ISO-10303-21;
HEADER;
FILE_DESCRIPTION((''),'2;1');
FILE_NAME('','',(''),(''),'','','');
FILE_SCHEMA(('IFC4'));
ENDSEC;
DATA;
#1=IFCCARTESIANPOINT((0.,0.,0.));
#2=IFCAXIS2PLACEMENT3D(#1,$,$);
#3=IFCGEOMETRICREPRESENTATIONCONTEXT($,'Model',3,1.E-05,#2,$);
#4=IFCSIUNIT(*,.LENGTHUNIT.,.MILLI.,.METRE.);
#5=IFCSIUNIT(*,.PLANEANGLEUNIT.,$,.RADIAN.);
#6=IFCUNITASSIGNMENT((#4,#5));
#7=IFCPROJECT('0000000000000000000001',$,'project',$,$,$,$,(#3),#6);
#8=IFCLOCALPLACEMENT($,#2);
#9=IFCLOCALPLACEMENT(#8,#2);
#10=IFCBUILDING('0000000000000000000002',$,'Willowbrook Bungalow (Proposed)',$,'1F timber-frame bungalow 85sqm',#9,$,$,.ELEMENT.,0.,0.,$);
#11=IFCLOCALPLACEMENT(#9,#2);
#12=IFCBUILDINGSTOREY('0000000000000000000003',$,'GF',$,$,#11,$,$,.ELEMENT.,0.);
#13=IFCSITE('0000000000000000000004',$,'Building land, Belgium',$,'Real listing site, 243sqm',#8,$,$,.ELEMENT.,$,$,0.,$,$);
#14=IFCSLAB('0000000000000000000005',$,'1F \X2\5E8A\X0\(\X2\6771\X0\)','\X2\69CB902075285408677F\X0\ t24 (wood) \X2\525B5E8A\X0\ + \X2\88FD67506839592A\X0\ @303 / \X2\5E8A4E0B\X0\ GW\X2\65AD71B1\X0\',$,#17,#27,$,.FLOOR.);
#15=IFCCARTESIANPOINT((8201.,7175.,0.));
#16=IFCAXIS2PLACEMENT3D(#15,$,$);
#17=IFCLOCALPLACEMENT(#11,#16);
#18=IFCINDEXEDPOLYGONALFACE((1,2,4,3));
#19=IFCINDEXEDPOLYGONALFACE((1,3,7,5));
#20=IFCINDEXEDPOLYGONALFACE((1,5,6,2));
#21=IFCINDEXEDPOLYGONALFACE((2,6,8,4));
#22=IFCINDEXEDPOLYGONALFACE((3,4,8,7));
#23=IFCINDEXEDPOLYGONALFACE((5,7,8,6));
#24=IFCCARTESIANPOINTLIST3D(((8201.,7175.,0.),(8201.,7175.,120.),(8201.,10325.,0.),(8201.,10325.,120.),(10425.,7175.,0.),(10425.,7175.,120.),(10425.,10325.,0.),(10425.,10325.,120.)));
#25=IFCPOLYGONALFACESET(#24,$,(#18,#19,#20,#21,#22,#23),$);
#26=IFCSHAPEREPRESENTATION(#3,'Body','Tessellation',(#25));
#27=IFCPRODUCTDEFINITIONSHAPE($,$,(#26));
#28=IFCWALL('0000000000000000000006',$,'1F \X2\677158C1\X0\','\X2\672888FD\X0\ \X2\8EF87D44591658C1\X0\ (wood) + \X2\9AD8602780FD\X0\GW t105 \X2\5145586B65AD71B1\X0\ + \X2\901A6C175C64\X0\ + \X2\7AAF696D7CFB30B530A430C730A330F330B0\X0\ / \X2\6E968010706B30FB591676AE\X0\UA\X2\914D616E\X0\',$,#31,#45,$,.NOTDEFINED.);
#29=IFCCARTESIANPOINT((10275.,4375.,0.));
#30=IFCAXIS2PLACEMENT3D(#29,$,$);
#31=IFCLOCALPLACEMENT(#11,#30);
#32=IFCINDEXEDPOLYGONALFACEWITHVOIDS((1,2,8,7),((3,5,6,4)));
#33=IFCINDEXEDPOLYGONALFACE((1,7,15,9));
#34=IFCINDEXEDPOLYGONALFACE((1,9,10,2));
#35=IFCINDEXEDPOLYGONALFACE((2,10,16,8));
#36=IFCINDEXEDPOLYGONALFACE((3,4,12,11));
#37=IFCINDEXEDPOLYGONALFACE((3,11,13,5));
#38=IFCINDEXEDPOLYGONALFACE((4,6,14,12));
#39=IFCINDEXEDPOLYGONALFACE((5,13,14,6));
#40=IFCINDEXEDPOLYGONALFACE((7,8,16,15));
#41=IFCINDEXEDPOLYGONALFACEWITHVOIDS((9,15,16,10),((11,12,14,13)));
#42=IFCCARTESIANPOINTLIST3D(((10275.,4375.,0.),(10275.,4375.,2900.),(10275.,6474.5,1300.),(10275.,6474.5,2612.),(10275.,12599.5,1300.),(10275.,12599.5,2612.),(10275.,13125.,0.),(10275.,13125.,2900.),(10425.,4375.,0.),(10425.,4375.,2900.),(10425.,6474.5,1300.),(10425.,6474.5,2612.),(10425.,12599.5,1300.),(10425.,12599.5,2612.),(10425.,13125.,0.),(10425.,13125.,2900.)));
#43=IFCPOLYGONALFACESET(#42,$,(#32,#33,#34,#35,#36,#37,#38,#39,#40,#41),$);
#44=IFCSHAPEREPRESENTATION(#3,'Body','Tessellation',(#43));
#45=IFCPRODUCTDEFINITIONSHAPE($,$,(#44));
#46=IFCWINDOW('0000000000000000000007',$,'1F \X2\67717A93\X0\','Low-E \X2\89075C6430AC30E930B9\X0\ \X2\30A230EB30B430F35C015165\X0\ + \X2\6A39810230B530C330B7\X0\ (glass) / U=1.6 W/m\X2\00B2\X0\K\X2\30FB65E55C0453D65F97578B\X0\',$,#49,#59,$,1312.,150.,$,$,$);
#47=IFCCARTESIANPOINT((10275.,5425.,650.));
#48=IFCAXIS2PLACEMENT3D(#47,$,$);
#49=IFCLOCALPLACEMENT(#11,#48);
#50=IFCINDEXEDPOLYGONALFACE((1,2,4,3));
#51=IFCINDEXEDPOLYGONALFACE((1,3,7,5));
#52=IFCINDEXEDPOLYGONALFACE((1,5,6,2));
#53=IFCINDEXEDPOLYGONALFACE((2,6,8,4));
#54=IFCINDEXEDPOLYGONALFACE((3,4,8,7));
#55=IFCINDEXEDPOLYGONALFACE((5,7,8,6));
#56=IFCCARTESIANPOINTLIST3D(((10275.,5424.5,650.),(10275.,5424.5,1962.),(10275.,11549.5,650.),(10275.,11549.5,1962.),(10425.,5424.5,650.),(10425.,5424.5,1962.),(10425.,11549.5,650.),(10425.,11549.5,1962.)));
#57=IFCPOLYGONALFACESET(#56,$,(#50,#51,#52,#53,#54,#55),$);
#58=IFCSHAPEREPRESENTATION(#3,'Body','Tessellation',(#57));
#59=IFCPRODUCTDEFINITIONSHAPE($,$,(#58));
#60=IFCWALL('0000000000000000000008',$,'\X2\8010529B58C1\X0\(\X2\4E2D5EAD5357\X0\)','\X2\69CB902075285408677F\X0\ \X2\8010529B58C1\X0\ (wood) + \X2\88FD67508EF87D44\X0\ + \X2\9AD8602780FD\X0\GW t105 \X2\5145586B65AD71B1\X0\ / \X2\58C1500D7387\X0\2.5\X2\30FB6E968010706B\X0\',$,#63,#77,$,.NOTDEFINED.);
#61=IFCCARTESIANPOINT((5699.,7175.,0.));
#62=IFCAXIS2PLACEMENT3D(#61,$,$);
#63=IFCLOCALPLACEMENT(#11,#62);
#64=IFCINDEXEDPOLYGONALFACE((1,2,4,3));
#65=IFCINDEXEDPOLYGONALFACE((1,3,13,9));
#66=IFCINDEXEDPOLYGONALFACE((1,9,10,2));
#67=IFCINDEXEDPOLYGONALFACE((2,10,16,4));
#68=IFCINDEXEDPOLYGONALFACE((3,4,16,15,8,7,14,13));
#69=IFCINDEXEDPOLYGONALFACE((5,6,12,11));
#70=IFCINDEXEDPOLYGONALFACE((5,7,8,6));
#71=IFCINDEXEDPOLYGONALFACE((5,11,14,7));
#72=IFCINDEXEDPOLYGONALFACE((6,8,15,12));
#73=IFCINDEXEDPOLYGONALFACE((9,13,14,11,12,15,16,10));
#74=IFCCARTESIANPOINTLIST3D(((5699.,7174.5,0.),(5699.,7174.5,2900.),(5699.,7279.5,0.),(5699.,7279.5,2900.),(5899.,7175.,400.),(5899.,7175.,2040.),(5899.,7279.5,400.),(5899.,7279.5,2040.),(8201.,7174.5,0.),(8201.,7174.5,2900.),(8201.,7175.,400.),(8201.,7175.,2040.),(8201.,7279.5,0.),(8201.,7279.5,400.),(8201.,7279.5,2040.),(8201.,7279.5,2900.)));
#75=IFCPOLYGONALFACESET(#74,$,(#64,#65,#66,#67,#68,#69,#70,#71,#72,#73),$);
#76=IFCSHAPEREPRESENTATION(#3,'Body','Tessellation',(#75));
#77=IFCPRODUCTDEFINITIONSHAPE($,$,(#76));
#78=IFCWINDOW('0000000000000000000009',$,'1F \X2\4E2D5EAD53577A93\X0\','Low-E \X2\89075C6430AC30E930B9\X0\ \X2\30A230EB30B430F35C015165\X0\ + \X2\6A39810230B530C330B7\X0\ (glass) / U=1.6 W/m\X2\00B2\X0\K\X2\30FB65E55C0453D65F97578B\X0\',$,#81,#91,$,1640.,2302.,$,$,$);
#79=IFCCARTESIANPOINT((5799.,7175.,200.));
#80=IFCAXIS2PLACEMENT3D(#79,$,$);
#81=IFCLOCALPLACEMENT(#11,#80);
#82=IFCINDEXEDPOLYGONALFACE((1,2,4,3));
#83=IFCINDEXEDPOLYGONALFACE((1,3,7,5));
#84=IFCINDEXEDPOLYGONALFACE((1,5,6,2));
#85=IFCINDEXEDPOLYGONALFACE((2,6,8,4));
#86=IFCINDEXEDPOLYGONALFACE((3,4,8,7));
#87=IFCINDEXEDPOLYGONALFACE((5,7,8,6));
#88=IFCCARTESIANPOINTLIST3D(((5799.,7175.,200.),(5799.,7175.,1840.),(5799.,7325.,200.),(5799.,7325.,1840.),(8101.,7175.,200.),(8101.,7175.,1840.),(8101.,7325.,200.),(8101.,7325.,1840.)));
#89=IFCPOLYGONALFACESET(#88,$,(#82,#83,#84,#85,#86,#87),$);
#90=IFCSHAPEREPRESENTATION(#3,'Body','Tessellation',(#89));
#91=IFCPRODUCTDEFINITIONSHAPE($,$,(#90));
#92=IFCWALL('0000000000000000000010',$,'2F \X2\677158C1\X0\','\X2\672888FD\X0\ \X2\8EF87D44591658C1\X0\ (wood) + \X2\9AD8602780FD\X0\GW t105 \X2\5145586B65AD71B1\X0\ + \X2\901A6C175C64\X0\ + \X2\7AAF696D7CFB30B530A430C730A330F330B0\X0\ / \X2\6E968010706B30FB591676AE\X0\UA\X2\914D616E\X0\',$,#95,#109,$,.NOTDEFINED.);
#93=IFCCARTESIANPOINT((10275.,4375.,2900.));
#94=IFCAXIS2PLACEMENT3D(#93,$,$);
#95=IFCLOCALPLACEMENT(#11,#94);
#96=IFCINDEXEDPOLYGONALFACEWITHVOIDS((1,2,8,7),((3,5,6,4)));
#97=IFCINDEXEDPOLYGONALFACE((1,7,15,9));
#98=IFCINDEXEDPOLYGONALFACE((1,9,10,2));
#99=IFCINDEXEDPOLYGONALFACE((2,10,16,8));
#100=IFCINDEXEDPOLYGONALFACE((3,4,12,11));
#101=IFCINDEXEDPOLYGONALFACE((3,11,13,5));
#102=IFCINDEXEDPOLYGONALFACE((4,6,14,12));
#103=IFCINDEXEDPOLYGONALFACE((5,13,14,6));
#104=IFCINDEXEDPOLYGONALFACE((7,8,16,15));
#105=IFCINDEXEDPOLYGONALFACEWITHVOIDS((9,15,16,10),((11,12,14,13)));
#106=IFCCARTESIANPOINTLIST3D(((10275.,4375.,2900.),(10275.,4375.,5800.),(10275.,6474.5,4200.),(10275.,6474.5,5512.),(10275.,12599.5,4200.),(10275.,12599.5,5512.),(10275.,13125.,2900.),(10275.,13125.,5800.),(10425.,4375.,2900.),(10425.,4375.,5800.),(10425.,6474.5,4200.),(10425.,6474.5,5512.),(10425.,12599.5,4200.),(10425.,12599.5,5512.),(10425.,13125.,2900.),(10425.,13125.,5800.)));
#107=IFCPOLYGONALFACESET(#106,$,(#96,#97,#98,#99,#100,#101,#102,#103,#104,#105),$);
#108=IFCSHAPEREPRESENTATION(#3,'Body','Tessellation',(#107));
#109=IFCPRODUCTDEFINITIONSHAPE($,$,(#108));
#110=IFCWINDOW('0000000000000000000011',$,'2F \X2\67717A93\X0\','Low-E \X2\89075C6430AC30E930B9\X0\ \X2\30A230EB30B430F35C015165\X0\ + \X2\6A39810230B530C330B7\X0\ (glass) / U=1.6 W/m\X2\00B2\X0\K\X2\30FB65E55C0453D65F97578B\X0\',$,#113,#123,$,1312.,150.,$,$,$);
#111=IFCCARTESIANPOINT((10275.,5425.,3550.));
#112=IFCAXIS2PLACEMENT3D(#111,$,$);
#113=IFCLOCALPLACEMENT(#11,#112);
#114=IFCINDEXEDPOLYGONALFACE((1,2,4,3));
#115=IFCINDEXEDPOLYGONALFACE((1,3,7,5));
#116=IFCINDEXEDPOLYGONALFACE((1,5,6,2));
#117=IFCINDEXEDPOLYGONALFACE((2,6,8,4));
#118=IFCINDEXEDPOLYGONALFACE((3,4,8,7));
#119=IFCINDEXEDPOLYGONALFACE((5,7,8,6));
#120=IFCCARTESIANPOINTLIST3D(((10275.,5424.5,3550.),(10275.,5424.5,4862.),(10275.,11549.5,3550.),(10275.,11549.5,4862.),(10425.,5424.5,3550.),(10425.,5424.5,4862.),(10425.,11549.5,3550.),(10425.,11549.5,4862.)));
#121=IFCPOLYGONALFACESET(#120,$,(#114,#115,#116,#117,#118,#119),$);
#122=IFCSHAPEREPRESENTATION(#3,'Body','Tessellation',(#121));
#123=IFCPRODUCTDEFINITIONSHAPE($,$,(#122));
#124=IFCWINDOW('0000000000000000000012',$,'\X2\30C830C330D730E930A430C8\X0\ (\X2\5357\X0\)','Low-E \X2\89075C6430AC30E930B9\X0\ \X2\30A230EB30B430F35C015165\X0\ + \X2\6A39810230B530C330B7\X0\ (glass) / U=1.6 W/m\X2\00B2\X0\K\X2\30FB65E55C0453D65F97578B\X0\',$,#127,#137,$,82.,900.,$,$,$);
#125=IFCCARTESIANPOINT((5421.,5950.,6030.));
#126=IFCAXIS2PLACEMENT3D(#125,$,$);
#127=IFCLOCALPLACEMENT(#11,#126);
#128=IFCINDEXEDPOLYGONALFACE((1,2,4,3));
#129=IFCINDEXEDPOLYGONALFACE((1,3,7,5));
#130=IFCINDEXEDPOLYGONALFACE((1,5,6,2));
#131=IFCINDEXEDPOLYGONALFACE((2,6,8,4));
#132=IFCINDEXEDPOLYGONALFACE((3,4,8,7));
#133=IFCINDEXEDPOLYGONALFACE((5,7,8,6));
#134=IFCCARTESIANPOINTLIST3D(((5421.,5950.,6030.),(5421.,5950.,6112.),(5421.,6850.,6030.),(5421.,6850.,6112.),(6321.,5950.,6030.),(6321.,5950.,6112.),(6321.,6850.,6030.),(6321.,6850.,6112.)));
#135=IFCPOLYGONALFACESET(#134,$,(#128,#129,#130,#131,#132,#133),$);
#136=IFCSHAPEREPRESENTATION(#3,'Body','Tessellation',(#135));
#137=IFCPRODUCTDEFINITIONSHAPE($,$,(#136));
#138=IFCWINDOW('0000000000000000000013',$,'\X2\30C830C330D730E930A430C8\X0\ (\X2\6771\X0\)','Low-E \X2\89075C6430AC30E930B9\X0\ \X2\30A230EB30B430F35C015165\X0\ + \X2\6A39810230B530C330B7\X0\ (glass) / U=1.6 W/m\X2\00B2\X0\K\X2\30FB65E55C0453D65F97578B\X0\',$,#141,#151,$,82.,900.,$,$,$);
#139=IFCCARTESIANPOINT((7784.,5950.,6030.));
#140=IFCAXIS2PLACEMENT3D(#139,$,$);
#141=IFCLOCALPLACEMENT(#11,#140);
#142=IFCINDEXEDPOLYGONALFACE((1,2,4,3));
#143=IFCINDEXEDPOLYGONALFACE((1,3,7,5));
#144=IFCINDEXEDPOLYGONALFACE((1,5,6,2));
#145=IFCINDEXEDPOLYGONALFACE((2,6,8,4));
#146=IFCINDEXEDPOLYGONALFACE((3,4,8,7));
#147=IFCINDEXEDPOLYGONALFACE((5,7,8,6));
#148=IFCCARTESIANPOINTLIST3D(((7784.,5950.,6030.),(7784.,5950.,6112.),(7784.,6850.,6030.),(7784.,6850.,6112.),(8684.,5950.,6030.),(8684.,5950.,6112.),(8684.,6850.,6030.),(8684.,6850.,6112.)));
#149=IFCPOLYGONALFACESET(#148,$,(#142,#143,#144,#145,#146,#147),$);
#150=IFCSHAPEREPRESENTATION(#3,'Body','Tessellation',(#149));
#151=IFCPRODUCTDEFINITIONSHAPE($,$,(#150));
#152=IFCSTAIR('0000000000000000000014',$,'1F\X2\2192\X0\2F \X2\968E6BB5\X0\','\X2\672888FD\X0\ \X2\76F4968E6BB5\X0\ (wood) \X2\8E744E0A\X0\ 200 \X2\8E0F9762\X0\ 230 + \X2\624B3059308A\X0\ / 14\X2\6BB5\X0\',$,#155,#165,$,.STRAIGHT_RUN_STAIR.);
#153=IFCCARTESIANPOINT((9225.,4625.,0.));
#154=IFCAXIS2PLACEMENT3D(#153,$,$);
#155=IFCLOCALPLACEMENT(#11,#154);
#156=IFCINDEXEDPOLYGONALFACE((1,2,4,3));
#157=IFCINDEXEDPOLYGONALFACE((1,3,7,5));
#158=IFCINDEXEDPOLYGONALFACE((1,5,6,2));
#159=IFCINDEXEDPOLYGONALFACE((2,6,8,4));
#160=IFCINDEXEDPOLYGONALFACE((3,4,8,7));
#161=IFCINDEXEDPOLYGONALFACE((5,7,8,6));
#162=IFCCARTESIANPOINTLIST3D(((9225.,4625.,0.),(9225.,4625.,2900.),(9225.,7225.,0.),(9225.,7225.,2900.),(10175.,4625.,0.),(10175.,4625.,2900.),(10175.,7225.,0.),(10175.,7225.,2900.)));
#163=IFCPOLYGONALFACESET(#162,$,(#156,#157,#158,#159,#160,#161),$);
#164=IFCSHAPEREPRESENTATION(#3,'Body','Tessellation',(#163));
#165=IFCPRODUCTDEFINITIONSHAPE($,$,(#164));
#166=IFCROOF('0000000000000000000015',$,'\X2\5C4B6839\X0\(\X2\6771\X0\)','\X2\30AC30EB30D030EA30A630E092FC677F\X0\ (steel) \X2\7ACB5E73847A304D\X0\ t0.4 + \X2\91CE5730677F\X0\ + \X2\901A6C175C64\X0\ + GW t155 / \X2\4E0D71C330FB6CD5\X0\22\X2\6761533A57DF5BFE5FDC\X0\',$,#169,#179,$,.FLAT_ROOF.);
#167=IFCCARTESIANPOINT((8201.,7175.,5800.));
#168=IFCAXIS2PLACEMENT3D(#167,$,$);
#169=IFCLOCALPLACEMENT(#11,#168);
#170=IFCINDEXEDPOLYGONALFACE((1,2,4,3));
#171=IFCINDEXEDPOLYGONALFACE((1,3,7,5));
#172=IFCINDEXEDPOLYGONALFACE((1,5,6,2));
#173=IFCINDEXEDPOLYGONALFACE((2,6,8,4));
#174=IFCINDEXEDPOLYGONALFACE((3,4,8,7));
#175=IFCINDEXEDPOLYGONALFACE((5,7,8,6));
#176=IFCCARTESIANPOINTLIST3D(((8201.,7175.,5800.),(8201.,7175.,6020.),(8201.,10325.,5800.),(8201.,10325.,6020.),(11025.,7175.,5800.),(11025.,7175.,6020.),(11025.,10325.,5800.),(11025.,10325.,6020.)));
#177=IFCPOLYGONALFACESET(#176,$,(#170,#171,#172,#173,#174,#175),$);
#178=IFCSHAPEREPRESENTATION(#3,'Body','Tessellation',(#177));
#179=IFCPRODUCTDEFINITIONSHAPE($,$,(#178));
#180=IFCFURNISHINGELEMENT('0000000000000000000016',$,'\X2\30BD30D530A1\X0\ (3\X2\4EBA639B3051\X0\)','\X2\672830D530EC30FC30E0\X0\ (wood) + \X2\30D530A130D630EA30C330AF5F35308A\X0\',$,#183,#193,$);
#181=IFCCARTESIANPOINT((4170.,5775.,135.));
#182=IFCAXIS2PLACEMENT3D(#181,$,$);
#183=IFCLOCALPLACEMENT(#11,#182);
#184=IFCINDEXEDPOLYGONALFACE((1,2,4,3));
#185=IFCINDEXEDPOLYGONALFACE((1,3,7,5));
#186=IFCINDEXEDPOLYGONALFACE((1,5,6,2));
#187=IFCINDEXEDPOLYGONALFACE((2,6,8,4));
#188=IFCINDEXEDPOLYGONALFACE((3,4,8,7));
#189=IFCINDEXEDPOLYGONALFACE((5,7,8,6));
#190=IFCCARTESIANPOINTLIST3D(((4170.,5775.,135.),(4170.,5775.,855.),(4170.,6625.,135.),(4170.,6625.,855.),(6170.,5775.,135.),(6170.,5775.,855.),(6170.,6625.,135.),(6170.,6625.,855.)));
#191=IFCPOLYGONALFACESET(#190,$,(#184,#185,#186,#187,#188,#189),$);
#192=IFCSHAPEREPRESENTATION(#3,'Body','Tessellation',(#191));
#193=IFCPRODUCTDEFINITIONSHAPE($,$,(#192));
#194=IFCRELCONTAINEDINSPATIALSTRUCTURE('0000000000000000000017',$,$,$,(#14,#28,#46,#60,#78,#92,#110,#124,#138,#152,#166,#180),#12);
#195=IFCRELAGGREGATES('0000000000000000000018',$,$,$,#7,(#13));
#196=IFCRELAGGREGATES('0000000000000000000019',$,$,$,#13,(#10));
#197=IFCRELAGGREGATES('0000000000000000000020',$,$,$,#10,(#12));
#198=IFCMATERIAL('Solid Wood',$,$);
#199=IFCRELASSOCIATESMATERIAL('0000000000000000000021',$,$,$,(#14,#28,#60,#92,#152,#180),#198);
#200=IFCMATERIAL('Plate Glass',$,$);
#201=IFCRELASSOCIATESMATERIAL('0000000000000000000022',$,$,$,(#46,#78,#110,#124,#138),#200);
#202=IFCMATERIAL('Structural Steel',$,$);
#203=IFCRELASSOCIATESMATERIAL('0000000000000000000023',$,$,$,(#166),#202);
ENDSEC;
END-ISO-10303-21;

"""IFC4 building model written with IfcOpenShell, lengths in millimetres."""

from ifc_helpers import new_model, si_unit, frame, frame_2d, origin, place, context, project, spatial, rectangle, extrude, material, element, fill, save


model = new_model("IFC4")

# Units and contexts
model_context = context("Model", 3, precision=1e-05, world=origin())
ifc_project = project(units=[si_unit("LENGTHUNIT", "METRE", prefix="MILLI"), si_unit("PLANEANGLEUNIT", "RADIAN")], contexts=[model_context])

# Site, building, storey
site_placement = place(None, origin())
site = spatial("IfcSite", under=ifc_project, at=site_placement, Name="Building land, Belgium", ObjectType="Real listing site, 243sqm", CompositionType="ELEMENT", RefElevation=0.0)
building_placement = place(site_placement, origin())
building = spatial("IfcBuilding", under=site, at=building_placement, Name="Willowbrook Bungalow (Proposed)", ObjectType="1F timber-frame bungalow 85sqm", CompositionType="ELEMENT", ElevationOfRefHeight=0.0, ElevationOfTerrain=0.0)
storey_placement = place(building_placement, origin())
storey = spatial("IfcBuildingStorey", under=building, at=storey_placement, Name="GF", CompositionType="ELEMENT", Elevation=0.0)

# Slab
ifc_material_1 = material(Name="Solid Wood")
slab_placement = place(storey_placement, frame((8201.0, 7175.0, 0.0)))
element("IfcSlab", 1, at=slab_placement, inside=storey, material=ifc_material_1, Name="1F 床(東)", Description="構造用合板 t24 (wood) 剛床 + 製材根太 @303 / 床下 GW断熱", PredefinedType="FLOOR", context=model_context, shape_type="SweptSolid", body=[
    extrude(rectangle(XDim=2224.0, YDim=3150.0, at=frame_2d((1112.0, 1575.0))), frame((8201.0, 7175.0, 0.0)), (0.0, 0.0, 1.0), 120.0),
])

# Walls, openings, windows
wall_1_placement = place(storey_placement, frame((10275.0, 4375.0, 0.0)))
wall_1 = element("IfcWall", 2, at=wall_1_placement, inside=storey, material=ifc_material_1, Name="1F 東壁", Description="木製 軸組外壁 (wood) + 高性能GW t105 充填断熱 + 通気層 + 窯業系サイディング / 準耐火・外皮UA配慮", PredefinedType="NOTDEFINED", context=model_context, shape_type="SweptSolid", body=[
    extrude(rectangle(XDim=150.0, YDim=8750.0, at=frame_2d((75.0, 4375.0))), frame((10275.0, 4375.0, 0.0)), (0.0, 0.0, 1.0), 2900.0),
])
opening_1_placement = place(storey_placement, frame((10275.0, 5425.0, 650.0)))
opening_1 = element("IfcOpeningElement", 3, at=opening_1_placement, cuts=wall_1, PredefinedType="NOTDEFINED", context=model_context, shape_type="SweptSolid", body=[
    extrude(rectangle(XDim=150.0, YDim=6125.0, at=frame_2d((75.0, 3062.0))), frame((10275.0, 5425.0, 650.0)), (0.0, 0.0, 1.0), 1312.0),
])
ifc_material_2 = material(Name="Plate Glass")
window_1_placement = place(storey_placement, frame((10275.0, 5425.0, 650.0)))
window_1 = element("IfcWindow", 4, at=window_1_placement, inside=storey, material=ifc_material_2, Name="1F 東窓", Description="Low-E 複層ガラス アルゴン封入 + 樹脂サッシ (glass) / U=1.6 W/m²K・日射取得型", OverallHeight=1312.0, OverallWidth=150.0, context=model_context, shape_type="SweptSolid", body=[
    extrude(rectangle(XDim=150.0, YDim=6125.0, at=frame_2d((75.0, 3062.0))), frame((10275.0, 5425.0, 650.0)), (0.0, 0.0, 1.0), 1312.0),
])
fill(opening_1, window_1)
wall_2_placement = place(storey_placement, frame((5699.0, 7175.0, 0.0)))
wall_2 = element("IfcWall", 5, at=wall_2_placement, inside=storey, material=ifc_material_1, Name="耐力壁(中庭南)", Description="構造用合板 耐力壁 (wood) + 製材軸組 + 高性能GW t105 充填断熱 / 壁倍率2.5・準耐火", PredefinedType="NOTDEFINED", context=model_context, shape_type="SweptSolid", body=[
    extrude(rectangle(XDim=2502.0, YDim=105.0, at=frame_2d((1251.0, 52.0))), frame((5699.0, 7175.0, 0.0)), (0.0, 0.0, 1.0), 2900.0),
])
opening_2_placement = place(storey_placement, frame((5799.0, 7175.0, 200.0)))
opening_2 = element("IfcOpeningElement", 6, at=opening_2_placement, cuts=wall_2, PredefinedType="NOTDEFINED", context=model_context, shape_type="SweptSolid", body=[
    extrude(rectangle(XDim=2302.0, YDim=150.0, at=frame_2d((1151.0, 75.0))), frame((5799.0, 7175.0, 200.0)), (0.0, 0.0, 1.0), 1640.0),
])
window_2_placement = place(storey_placement, frame((5799.0, 7175.0, 200.0)))
window_2 = element("IfcWindow", 7, at=window_2_placement, inside=storey, material=ifc_material_2, Name="1F 中庭南窓", Description="Low-E 複層ガラス アルゴン封入 + 樹脂サッシ (glass) / U=1.6 W/m²K・日射取得型", OverallHeight=1640.0, OverallWidth=2302.0, context=model_context, shape_type="SweptSolid", body=[
    extrude(rectangle(XDim=2302.0, YDim=150.0, at=frame_2d((1151.0, 75.0))), frame((5799.0, 7175.0, 200.0)), (0.0, 0.0, 1.0), 1640.0),
])
fill(opening_2, window_2)

# Wall, opening, window
wall_3_placement = place(storey_placement, frame((10275.0, 4375.0, 2900.0)))
wall_3 = element("IfcWall", 8, at=wall_3_placement, inside=storey, material=ifc_material_1, Name="2F 東壁", Description="木製 軸組外壁 (wood) + 高性能GW t105 充填断熱 + 通気層 + 窯業系サイディング / 準耐火・外皮UA配慮", PredefinedType="NOTDEFINED", context=model_context, shape_type="SweptSolid", body=[
    extrude(rectangle(XDim=150.0, YDim=8750.0, at=frame_2d((75.0, 4375.0))), frame((10275.0, 4375.0, 2900.0)), (0.0, 0.0, 1.0), 2900.0),
])
opening_3_placement = place(storey_placement, frame((10275.0, 5425.0, 3550.0)))
opening_3 = element("IfcOpeningElement", 9, at=opening_3_placement, cuts=wall_3, PredefinedType="NOTDEFINED", context=model_context, shape_type="SweptSolid", body=[
    extrude(rectangle(XDim=150.0, YDim=6125.0, at=frame_2d((75.0, 3062.0))), frame((10275.0, 5425.0, 3550.0)), (0.0, 0.0, 1.0), 1312.0),
])
window_3_placement = place(storey_placement, frame((10275.0, 5425.0, 3550.0)))
window_3 = element("IfcWindow", 10, at=window_3_placement, inside=storey, material=ifc_material_2, Name="2F 東窓", Description="Low-E 複層ガラス アルゴン封入 + 樹脂サッシ (glass) / U=1.6 W/m²K・日射取得型", OverallHeight=1312.0, OverallWidth=150.0, context=model_context, shape_type="SweptSolid", body=[
    extrude(rectangle(XDim=150.0, YDim=6125.0, at=frame_2d((75.0, 3062.0))), frame((10275.0, 5425.0, 3550.0)), (0.0, 0.0, 1.0), 1312.0),
])
fill(opening_3, window_3)

# Windows
window_4_placement = place(storey_placement, frame((5421.0, 5950.0, 6030.0)))
element("IfcWindow", 11, at=window_4_placement, inside=storey, material=ifc_material_2, Name="トップライト (南)", Description="Low-E 複層ガラス アルゴン封入 + 樹脂サッシ (glass) / U=1.6 W/m²K・日射取得型", OverallHeight=82.0, OverallWidth=900.0, context=model_context, shape_type="SweptSolid", body=[
    extrude(rectangle(XDim=900.0, YDim=900.0, at=frame_2d((450.0, 450.0))), frame((5421.0, 5950.0, 6030.0)), (0.0, 0.0, 1.0), 82.0),
])
window_5_placement = place(storey_placement, frame((7784.0, 5950.0, 6030.0)))
element("IfcWindow", 12, at=window_5_placement, inside=storey, material=ifc_material_2, Name="トップライト (東)", Description="Low-E 複層ガラス アルゴン封入 + 樹脂サッシ (glass) / U=1.6 W/m²K・日射取得型", OverallHeight=82.0, OverallWidth=900.0, context=model_context, shape_type="SweptSolid", body=[
    extrude(rectangle(XDim=900.0, YDim=900.0, at=frame_2d((450.0, 450.0))), frame((7784.0, 5950.0, 6030.0)), (0.0, 0.0, 1.0), 82.0),
])

# Stair
stair_placement = place(storey_placement, frame((9225.0, 4625.0, 0.0)))
element("IfcStair", 13, at=stair_placement, inside=storey, material=ifc_material_1, Name="1F→2F 階段", Description="木製 直階段 (wood) 蹴上 200 踏面 230 + 手すり / 14段", PredefinedType="STRAIGHT_RUN_STAIR", context=model_context, shape_type="SweptSolid", body=[
    extrude(rectangle(XDim=950.0, YDim=2600.0, at=frame_2d((475.0, 1300.0))), frame((9225.0, 4625.0, 0.0)), (0.0, 0.0, 1.0), 2900.0),
])

# Roof
ifc_material_3 = material(Name="Structural Steel")
roof_placement = place(storey_placement, frame((8201.0, 7175.0, 5800.0)))
element("IfcRoof", 14, at=roof_placement, inside=storey, material=ifc_material_3, Name="屋根(東)", Description="ガルバリウム鋼板 (steel) 立平葺き t0.4 + 野地板 + 通気層 + GW t155 / 不燃・法22条区域対応", PredefinedType="FLAT_ROOF", context=model_context, shape_type="SweptSolid", body=[
    extrude(rectangle(XDim=2824.0, YDim=3150.0, at=frame_2d((1412.0, 1575.0))), frame((8201.0, 7175.0, 5800.0)), (0.0, 0.0, 1.0), 220.0),
])

# Furnishing element
furnishing_1_placement = place(storey_placement, frame((4170.0, 5775.0, 135.0)))
element("IfcFurnishingElement", 15, at=furnishing_1_placement, inside=storey, material=ifc_material_1, Name="ソファ (3人掛け)", Description="木フレーム (wood) + ファブリック張り", context=model_context, shape_type="SweptSolid", body=[
    extrude(rectangle(XDim=2000.0, YDim=850.0, at=frame_2d((1000.0, 425.0))), frame((4170.0, 5775.0, 135.0)), (0.0, 0.0, 1.0), 720.0),
])

save(model, "model.ifc")
